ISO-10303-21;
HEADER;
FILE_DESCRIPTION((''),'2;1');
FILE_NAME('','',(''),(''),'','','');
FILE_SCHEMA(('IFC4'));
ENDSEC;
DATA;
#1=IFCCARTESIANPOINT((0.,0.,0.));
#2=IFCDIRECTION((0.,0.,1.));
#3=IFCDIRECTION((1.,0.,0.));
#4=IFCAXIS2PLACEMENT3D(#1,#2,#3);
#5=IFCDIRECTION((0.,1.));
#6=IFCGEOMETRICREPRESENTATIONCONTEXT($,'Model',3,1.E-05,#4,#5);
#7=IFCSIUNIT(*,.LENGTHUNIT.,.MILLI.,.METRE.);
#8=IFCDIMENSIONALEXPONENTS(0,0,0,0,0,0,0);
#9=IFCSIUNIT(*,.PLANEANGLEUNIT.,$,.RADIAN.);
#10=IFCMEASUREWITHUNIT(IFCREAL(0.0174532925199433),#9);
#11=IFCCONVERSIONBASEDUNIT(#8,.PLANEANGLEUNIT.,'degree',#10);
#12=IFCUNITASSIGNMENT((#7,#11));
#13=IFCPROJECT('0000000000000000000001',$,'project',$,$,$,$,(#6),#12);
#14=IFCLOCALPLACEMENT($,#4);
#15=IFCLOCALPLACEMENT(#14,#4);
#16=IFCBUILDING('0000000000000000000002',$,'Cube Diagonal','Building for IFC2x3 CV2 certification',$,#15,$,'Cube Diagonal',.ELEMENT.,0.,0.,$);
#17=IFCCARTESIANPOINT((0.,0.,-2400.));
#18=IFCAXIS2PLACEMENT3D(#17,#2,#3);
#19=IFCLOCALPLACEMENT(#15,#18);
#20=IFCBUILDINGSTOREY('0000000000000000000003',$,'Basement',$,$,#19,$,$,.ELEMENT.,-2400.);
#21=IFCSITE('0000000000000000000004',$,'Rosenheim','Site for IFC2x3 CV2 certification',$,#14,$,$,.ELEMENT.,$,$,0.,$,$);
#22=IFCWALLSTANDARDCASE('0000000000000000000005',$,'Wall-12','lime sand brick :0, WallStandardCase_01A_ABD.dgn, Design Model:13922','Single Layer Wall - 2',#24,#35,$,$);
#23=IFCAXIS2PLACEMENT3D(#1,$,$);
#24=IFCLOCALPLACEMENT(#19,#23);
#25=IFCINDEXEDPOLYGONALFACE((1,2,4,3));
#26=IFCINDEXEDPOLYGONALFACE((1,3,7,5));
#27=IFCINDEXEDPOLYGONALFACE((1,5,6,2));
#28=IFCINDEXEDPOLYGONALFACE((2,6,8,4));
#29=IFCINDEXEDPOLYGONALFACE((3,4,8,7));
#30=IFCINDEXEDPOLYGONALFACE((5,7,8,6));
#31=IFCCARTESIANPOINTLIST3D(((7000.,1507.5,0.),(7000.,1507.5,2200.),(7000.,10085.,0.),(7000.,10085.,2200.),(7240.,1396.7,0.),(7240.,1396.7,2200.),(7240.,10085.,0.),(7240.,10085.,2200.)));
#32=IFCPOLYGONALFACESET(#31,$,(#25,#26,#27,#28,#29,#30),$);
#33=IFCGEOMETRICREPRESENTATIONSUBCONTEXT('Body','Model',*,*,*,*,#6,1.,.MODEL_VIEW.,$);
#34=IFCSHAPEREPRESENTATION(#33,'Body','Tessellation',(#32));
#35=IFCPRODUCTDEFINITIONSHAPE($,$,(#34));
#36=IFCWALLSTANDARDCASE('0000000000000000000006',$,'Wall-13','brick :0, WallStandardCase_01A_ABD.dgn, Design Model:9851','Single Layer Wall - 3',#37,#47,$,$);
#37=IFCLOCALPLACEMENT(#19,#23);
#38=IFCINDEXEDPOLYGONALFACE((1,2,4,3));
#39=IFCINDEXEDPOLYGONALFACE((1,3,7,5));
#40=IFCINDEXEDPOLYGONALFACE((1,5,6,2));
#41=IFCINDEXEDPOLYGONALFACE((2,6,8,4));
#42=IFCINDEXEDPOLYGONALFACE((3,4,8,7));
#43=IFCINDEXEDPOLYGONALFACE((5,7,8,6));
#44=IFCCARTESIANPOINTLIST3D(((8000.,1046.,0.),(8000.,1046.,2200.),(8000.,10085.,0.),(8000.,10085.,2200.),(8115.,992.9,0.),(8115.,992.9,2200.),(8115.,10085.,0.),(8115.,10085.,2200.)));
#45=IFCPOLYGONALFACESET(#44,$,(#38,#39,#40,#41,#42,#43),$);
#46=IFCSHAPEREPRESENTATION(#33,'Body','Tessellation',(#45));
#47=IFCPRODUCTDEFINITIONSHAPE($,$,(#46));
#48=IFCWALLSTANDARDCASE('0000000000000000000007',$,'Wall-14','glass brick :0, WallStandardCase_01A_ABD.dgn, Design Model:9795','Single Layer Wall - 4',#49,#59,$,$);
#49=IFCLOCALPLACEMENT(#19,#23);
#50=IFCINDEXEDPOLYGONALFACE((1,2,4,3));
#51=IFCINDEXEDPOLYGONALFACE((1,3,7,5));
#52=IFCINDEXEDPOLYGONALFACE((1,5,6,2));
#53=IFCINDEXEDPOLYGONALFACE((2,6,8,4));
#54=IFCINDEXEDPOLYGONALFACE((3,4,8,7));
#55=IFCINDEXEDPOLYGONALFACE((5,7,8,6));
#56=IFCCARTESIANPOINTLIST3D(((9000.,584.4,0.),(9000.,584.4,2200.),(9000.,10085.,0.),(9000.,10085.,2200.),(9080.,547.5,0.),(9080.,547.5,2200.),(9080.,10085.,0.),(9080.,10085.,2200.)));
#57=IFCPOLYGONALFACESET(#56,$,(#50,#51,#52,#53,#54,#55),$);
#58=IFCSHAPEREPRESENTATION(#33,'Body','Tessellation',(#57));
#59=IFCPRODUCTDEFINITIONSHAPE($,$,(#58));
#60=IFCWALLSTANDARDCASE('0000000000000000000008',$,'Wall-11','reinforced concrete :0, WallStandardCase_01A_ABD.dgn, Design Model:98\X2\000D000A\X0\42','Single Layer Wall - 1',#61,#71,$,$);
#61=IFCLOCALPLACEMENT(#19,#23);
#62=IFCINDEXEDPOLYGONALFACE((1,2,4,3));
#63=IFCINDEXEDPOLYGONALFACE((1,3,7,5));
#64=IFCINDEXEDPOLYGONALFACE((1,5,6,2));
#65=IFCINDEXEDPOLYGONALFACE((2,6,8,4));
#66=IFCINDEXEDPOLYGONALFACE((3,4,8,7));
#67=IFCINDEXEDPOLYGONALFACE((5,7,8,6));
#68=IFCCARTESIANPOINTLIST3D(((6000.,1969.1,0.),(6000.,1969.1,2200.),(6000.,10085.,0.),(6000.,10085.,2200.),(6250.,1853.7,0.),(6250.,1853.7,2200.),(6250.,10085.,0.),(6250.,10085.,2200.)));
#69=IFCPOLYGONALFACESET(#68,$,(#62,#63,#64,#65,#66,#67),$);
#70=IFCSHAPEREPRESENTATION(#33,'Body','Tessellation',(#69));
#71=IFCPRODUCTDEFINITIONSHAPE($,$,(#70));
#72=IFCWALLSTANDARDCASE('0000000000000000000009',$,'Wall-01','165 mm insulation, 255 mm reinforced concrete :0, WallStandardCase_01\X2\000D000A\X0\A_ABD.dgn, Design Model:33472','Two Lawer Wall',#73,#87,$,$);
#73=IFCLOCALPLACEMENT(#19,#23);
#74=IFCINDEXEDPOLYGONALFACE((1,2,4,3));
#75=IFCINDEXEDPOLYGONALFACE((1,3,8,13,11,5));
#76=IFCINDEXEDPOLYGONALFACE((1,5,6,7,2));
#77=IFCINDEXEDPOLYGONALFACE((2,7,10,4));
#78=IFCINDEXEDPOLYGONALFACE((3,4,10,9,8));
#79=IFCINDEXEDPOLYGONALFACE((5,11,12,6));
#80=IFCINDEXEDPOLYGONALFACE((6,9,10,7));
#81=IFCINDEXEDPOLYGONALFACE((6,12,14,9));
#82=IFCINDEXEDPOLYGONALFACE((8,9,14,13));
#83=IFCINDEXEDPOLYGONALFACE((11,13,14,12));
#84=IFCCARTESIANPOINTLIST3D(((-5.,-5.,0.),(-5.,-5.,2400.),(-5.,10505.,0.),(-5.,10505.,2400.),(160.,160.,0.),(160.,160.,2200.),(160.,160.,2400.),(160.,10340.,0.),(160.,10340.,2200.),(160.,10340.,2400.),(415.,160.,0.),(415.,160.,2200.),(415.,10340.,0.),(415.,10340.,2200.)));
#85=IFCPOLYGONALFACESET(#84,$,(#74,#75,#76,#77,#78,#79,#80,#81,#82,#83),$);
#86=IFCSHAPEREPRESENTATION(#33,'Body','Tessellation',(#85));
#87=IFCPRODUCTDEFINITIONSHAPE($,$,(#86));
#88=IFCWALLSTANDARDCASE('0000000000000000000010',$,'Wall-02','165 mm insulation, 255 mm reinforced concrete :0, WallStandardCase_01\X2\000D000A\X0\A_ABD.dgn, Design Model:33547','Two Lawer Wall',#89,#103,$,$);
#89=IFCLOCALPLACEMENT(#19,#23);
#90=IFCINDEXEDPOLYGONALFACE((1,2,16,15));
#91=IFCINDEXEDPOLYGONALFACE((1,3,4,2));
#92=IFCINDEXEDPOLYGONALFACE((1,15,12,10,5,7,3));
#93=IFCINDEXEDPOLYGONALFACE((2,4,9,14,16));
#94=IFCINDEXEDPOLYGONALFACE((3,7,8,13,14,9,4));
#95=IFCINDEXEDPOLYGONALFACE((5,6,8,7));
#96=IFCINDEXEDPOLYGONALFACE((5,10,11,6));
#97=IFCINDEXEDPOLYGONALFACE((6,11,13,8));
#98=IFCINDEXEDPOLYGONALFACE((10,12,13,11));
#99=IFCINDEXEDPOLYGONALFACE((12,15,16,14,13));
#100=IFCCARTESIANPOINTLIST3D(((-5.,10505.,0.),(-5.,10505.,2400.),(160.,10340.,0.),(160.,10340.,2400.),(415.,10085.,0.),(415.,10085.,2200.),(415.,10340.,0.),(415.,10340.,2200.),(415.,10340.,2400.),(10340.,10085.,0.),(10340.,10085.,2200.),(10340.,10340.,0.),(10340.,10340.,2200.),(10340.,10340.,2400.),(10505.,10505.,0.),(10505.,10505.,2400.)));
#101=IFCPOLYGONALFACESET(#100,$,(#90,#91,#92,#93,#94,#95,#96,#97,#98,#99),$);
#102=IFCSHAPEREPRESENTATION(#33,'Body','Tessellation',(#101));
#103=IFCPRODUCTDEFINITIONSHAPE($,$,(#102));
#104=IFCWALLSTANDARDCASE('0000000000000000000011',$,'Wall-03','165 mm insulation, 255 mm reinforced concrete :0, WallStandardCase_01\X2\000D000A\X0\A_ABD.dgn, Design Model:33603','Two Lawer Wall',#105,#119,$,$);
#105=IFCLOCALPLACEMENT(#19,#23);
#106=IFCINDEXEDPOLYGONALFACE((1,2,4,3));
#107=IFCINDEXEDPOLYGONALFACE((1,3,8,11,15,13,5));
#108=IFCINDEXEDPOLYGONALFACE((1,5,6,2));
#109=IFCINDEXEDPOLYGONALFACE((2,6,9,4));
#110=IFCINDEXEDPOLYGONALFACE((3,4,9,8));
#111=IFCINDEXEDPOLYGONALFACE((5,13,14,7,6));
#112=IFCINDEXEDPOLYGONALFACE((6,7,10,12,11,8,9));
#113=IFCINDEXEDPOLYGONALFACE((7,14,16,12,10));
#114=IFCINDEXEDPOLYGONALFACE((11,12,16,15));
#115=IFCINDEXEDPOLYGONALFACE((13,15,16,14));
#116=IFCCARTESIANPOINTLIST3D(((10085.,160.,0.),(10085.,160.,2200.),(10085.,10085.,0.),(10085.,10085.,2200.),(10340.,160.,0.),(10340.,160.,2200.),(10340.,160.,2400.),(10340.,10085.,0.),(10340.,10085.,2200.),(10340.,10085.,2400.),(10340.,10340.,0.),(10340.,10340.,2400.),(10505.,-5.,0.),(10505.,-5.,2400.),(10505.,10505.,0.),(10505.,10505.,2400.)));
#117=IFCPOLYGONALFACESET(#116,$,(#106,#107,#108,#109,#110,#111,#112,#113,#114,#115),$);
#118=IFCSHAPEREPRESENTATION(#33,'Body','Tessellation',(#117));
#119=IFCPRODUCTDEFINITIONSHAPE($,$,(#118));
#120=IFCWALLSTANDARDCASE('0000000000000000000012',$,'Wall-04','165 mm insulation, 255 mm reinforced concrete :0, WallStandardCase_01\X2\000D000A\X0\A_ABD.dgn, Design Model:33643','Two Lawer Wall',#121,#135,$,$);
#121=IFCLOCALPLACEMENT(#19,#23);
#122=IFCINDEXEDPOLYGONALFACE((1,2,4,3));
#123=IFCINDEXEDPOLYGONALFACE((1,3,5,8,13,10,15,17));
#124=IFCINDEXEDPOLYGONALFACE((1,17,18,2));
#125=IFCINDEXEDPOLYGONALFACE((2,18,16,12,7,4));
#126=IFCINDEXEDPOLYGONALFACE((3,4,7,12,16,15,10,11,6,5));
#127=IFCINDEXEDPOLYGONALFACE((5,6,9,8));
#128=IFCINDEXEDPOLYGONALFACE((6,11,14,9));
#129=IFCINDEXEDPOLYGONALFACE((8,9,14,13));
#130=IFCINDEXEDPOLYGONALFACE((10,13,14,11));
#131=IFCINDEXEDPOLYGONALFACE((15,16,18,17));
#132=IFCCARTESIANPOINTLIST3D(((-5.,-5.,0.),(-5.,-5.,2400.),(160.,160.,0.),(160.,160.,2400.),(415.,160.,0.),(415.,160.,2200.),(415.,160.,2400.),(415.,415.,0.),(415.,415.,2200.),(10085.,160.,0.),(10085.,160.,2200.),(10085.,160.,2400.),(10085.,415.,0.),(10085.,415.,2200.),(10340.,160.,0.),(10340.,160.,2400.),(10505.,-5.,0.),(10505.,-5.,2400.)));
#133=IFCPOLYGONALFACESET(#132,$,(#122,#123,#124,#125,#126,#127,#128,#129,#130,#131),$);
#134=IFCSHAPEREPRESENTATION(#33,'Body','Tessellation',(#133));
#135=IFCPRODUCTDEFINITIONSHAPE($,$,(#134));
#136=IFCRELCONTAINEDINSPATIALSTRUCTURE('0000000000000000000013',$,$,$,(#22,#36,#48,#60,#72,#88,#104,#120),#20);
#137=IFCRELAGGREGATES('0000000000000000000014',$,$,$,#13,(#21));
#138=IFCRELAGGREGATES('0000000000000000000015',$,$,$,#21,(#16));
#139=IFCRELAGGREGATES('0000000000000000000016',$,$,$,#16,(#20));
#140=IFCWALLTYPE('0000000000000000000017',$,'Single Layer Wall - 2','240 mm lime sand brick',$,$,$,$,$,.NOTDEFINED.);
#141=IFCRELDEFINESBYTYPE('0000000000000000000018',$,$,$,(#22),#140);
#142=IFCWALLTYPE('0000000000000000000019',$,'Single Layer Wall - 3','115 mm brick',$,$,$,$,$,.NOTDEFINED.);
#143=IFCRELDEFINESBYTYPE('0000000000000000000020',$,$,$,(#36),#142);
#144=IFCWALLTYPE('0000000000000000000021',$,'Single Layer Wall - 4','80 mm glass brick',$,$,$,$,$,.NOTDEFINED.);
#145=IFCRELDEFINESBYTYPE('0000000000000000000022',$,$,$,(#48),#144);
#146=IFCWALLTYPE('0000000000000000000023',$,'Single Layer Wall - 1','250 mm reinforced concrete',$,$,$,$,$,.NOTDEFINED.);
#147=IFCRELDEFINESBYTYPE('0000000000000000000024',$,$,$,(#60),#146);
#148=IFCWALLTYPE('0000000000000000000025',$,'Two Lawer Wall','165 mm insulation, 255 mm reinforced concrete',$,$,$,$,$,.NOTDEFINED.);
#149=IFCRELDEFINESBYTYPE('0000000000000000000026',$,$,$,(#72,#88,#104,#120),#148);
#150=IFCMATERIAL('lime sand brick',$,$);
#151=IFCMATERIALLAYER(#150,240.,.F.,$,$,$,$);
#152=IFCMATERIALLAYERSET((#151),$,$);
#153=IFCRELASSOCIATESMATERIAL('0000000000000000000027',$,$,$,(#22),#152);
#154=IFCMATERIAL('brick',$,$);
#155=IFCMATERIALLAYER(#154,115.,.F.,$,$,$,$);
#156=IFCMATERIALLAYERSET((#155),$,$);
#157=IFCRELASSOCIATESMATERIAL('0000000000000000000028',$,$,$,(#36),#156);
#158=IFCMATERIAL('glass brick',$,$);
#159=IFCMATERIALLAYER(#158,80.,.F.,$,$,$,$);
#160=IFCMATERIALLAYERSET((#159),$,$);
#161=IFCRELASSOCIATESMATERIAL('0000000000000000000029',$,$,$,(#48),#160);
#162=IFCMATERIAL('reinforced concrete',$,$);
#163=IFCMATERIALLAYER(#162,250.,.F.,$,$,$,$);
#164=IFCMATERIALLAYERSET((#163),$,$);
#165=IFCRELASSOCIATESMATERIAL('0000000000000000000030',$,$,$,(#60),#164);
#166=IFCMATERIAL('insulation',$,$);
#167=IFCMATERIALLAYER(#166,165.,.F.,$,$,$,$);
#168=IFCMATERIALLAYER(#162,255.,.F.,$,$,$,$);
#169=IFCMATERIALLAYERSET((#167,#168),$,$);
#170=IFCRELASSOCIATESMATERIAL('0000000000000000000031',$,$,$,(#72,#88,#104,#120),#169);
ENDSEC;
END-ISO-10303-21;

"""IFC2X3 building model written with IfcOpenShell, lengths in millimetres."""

from ifc_helpers import new_model, entity, si_unit, converted_unit, direction, frame, origin_with_axes, place, context, subcontext, project, spatial, polyline, outline, extrude, clip, bounded_halfspace, material, layer, layer_set, layer_usage, type_object, element, save


model = new_model("IFC2X3")

# Units and contexts
model_context = context("Model", 3, precision=1e-05, world=origin_with_axes(), true_north=direction((0.0, 1.0)))
body_context = subcontext(model_context, "Body", "Model", "MODEL_VIEW", scale=1.0)
ifc_project = project(units=[si_unit("LENGTHUNIT", "METRE", prefix="MILLI"), converted_unit("PLANEANGLEUNIT", "degree", entity("IfcReal", 0.0174532925199433), si_unit("PLANEANGLEUNIT", "RADIAN"), dimensions=[0, 0, 0, 0, 0, 0, 0])], contexts=[model_context])

# Site, building, storey
site_placement = place(None, origin_with_axes())
site = spatial("IfcSite", under=ifc_project, at=site_placement, Name="Rosenheim", Description="Site for IFC2x3 CV2 certification", CompositionType="ELEMENT", RefElevation=0.0)
building_placement = place(site_placement, origin_with_axes())
building = spatial("IfcBuilding", under=site, at=building_placement, Name="Cube Diagonal", Description="Building for IFC2x3 CV2 certification", LongName="Cube Diagonal", CompositionType="ELEMENT", ElevationOfRefHeight=0.0, ElevationOfTerrain=0.0)
storey_placement = place(building_placement, frame((0.0, 0.0, -2400.0), z_axis=(0.0, 0.0, 1.0), x_axis=(1.0, 0.0, 0.0)))
storey = spatial("IfcBuildingStorey", under=building, at=storey_placement, Name="Basement", CompositionType="ELEMENT", Elevation=-2400.0)

# Walls
ifc_material_1 = material(Name="lime sand brick")
ifc_layer_1 = layer(ifc_material_1, 240.0, ventilated=False)
ifc_layer_set_1 = layer_set([ifc_layer_1])
ifc_layer_usage_1 = layer_usage(ifc_layer_set_1, "AXIS2", "POSITIVE", 0.0)
wall_type_1 = type_object("IfcWallType", Name="Single Layer Wall - 2", Description="240 mm lime sand brick", PredefinedType="NOTDEFINED")
wall_1_placement = place(storey_placement, frame((7000.0, 1507.5, 0.0), z_axis=(0.0, 0.0, 1.0), x_axis=(0.0, 1.0, 0.0)))
element("IfcWallStandardCase", 1, at=wall_1_placement, inside=storey, type_object=wall_type_1, material=ifc_layer_usage_1, Name="Wall-12", Description="lime sand brick :0, WallStandardCase_01A_ABD.dgn, Design Model:13922", ObjectType="Single Layer Wall - 2", context=body_context, shape_type="SweptSolid", body=[
    extrude(outline(polyline([(8577.5, 0.0), (0.0, 0.0), (-110.8, -240.0), (8577.5, -240.0), (8577.5, 0.0)])), origin_with_axes(), (0.0, 0.0, 1.0), 2200.0),
])
ifc_material_2 = material(Name="brick")
ifc_layer_2 = layer(ifc_material_2, 115.0, ventilated=False)
ifc_layer_set_2 = layer_set([ifc_layer_2])
ifc_layer_usage_2 = layer_usage(ifc_layer_set_2, "AXIS2", "POSITIVE", 0.0)
wall_type_2 = type_object("IfcWallType", Name="Single Layer Wall - 3", Description="115 mm brick", PredefinedType="NOTDEFINED")
wall_2_placement = place(storey_placement, frame((8000.0, 1046.0, 0.0), z_axis=(0.0, 0.0, 1.0), x_axis=(0.0, 1.0, 0.0)))
element("IfcWallStandardCase", 2, at=wall_2_placement, inside=storey, type_object=wall_type_2, material=ifc_layer_usage_2, Name="Wall-13", Description="brick :0, WallStandardCase_01A_ABD.dgn, Design Model:9851", ObjectType="Single Layer Wall - 3", context=body_context, shape_type="SweptSolid", body=[
    extrude(outline(polyline([(9039.0, 0.0), (0.0, 0.0), (-53.1, -115.0), (9039.0, -115.0), (9039.0, 0.0)])), origin_with_axes(), (0.0, 0.0, 1.0), 2200.0),
])
ifc_material_3 = material(Name="glass brick")
ifc_layer_3 = layer(ifc_material_3, 80.0, ventilated=False)
ifc_layer_set_3 = layer_set([ifc_layer_3])
ifc_layer_usage_3 = layer_usage(ifc_layer_set_3, "AXIS2", "POSITIVE", 0.0)
wall_type_3 = type_object("IfcWallType", Name="Single Layer Wall - 4", Description="80 mm glass brick", PredefinedType="NOTDEFINED")
wall_3_placement = place(storey_placement, frame((9000.0, 584.4, 0.0), z_axis=(0.0, 0.0, 1.0), x_axis=(0.0, 1.0, 0.0)))
element("IfcWallStandardCase", 3, at=wall_3_placement, inside=storey, type_object=wall_type_3, material=ifc_layer_usage_3, Name="Wall-14", Description="glass brick :0, WallStandardCase_01A_ABD.dgn, Design Model:9795", ObjectType="Single Layer Wall - 4", context=body_context, shape_type="SweptSolid", body=[
    extrude(outline(polyline([(9500.6, 0.0), (0.0, 0.0), (-36.9, -80.0), (9500.6, -80.0), (9500.6, 0.0)])), origin_with_axes(), (0.0, 0.0, 1.0), 2200.0),
])
ifc_material_4 = material(Name="reinforced concrete")
ifc_layer_4 = layer(ifc_material_4, 250.0, ventilated=False)
ifc_layer_set_4 = layer_set([ifc_layer_4])
ifc_layer_usage_4 = layer_usage(ifc_layer_set_4, "AXIS2", "POSITIVE", 0.0)
wall_type_4 = type_object("IfcWallType", Name="Single Layer Wall - 1", Description="250 mm reinforced concrete", PredefinedType="NOTDEFINED")
wall_4_placement = place(storey_placement, frame((6000.0, 1969.1, 0.0), z_axis=(0.0, 0.0, 1.0), x_axis=(0.0, 1.0, 0.0)))
element("IfcWallStandardCase", 4, at=wall_4_placement, inside=storey, type_object=wall_type_4, material=ifc_layer_usage_4, Name="Wall-11", Description="reinforced concrete :0, WallStandardCase_01A_ABD.dgn, Design Model:98\r\n42", ObjectType="Single Layer Wall - 1", context=body_context, shape_type="SweptSolid", body=[
    extrude(outline(polyline([(8115.9, 0.0), (0.0, 0.0), (-115.4, -250.0), (8115.9, -250.0), (8115.9, 0.0)])), origin_with_axes(), (0.0, 0.0, 1.0), 2200.0),
])
ifc_material_5 = material(Name="insulation")
wall_type_5 = type_object("IfcWallType", Name="Two Lawer Wall", Description="165 mm insulation, 255 mm reinforced concrete", PredefinedType="NOTDEFINED")
ifc_layer_5 = layer(ifc_material_5, 165.0, ventilated=False)
ifc_layer_6 = layer(ifc_material_4, 255.0, ventilated=False)
ifc_layer_set_5 = layer_set([ifc_layer_5, ifc_layer_6])
ifc_layer_usage_5 = layer_usage(ifc_layer_set_5, "AXIS2", "POSITIVE", 0.0)
wall_5_placement = place(storey_placement, frame((415.0, 10340.0, 0.0), z_axis=(0.0, 0.0, 1.0), x_axis=(0.0, -1.0, 0.0)))
element("IfcWallStandardCase", 5, at=wall_5_placement, inside=storey, type_object=wall_type_5, material=ifc_layer_usage_5, Name="Wall-01", Description="165 mm insulation, 255 mm reinforced concrete :0, WallStandardCase_01\r\nA_ABD.dgn, Design Model:33472", ObjectType="Two Lawer Wall", context=body_context, shape_type="Clipping", body=[
    clip(extrude(outline(polyline([(10180.0, -255.0), (10180.0, 0.0), (0.0, 0.0), (0.0, -255.0), (-165.0, -420.0), (10345.0, -420.0), (10180.0, -255.0)])), origin_with_axes(), (0.0, 0.0, 1.0), 2400.0), bounded_halfspace(frame((0.0, 0.0, 2200.0), z_axis=(0.0, 0.0, 1.0), x_axis=(1.0, 0.0, 0.0)), False, frame((0.0, 0.0, 2200.0), z_axis=(0.0, 0.0, 1.0), x_axis=(1.0, 0.0, 0.0)), polyline([(10180.0, 0.0), (0.0, 0.0), (0.0, -255.0), (10180.0, -255.0), (10180.0, 0.0)]))),
])
for number, where, z_axis, x_axis, name, description in (
    (6, (10340.0, 10085.0, 0.0), (0.0, 0.0, 1.0), (-1.0, 0.0, 0.0), "Wall-02", "165 mm insulation, 255 mm reinforced concrete :0, WallStandardCase_01\r\nA_ABD.dgn, Design Model:33547"),
    (7, (10085.0, 160.0, 0.0), (0.0, 0.0, 1.0), (0.0, 1.0, 0.0), "Wall-03", "165 mm insulation, 255 mm reinforced concrete :0, WallStandardCase_01\r\nA_ABD.dgn, Design Model:33603"),
):
    element("IfcWallStandardCase", number, at=place(storey_placement, frame(where, z_axis=z_axis, x_axis=x_axis)), inside=storey, type_object=wall_type_5, material=ifc_layer_usage_5, Name=name, Description=description, ObjectType="Two Lawer Wall", context=body_context, shape_type="Clipping", body=[
        clip(extrude(outline(polyline([(9925.0, -255.0), (9925.0, 0.0), (0.0, 0.0), (0.0, -255.0), (-165.0, -420.0), (10345.0, -420.0), (10180.0, -255.0), (9925.0, -255.0)])), origin_with_axes(), (0.0, 0.0, 1.0), 2400.0), bounded_halfspace(frame((0.0, 0.0, 2200.0), z_axis=(0.0, 0.0, 1.0), x_axis=(1.0, 0.0, 0.0)), False, frame((0.0, 0.0, 2200.0), z_axis=(0.0, 0.0, 1.0), x_axis=(1.0, 0.0, 0.0)), polyline([(9925.0, 0.0), (0.0, 0.0), (0.0, -255.0), (9925.0, -255.0), (9925.0, 0.0)]))),
    ])
wall_6_placement = place(storey_placement, frame((415.0, 415.0, 0.0), z_axis=(0.0, 0.0, 1.0), x_axis=(1.0, 0.0, 0.0)))
element("IfcWallStandardCase", 8, at=wall_6_placement, inside=storey, type_object=wall_type_5, material=ifc_layer_usage_5, Name="Wall-04", Description="165 mm insulation, 255 mm reinforced concrete :0, WallStandardCase_01\r\nA_ABD.dgn, Design Model:33643", ObjectType="Two Lawer Wall", context=body_context, shape_type="Clipping", body=[
    clip(extrude(outline(polyline([(9670.0, -255.0), (9670.0, 0.0), (0.0, 0.0), (0.0, -255.0), (-255.0, -255.0), (-420.0, -420.0), (10090.0, -420.0), (9925.0, -255.0), (9670.0, -255.0)])), origin_with_axes(), (0.0, 0.0, 1.0), 2400.0), bounded_halfspace(frame((0.0, 0.0, 2200.0), z_axis=(0.0, 0.0, 1.0), x_axis=(1.0, 0.0, 0.0)), False, frame((0.0, 0.0, 2200.0), z_axis=(0.0, 0.0, 1.0), x_axis=(1.0, 0.0, 0.0)), polyline([(9670.0, 0.0), (0.0, 0.0), (0.0, -255.0), (9670.0, -255.0), (9670.0, 0.0)]))),
])

save(model, "model.ifc")
